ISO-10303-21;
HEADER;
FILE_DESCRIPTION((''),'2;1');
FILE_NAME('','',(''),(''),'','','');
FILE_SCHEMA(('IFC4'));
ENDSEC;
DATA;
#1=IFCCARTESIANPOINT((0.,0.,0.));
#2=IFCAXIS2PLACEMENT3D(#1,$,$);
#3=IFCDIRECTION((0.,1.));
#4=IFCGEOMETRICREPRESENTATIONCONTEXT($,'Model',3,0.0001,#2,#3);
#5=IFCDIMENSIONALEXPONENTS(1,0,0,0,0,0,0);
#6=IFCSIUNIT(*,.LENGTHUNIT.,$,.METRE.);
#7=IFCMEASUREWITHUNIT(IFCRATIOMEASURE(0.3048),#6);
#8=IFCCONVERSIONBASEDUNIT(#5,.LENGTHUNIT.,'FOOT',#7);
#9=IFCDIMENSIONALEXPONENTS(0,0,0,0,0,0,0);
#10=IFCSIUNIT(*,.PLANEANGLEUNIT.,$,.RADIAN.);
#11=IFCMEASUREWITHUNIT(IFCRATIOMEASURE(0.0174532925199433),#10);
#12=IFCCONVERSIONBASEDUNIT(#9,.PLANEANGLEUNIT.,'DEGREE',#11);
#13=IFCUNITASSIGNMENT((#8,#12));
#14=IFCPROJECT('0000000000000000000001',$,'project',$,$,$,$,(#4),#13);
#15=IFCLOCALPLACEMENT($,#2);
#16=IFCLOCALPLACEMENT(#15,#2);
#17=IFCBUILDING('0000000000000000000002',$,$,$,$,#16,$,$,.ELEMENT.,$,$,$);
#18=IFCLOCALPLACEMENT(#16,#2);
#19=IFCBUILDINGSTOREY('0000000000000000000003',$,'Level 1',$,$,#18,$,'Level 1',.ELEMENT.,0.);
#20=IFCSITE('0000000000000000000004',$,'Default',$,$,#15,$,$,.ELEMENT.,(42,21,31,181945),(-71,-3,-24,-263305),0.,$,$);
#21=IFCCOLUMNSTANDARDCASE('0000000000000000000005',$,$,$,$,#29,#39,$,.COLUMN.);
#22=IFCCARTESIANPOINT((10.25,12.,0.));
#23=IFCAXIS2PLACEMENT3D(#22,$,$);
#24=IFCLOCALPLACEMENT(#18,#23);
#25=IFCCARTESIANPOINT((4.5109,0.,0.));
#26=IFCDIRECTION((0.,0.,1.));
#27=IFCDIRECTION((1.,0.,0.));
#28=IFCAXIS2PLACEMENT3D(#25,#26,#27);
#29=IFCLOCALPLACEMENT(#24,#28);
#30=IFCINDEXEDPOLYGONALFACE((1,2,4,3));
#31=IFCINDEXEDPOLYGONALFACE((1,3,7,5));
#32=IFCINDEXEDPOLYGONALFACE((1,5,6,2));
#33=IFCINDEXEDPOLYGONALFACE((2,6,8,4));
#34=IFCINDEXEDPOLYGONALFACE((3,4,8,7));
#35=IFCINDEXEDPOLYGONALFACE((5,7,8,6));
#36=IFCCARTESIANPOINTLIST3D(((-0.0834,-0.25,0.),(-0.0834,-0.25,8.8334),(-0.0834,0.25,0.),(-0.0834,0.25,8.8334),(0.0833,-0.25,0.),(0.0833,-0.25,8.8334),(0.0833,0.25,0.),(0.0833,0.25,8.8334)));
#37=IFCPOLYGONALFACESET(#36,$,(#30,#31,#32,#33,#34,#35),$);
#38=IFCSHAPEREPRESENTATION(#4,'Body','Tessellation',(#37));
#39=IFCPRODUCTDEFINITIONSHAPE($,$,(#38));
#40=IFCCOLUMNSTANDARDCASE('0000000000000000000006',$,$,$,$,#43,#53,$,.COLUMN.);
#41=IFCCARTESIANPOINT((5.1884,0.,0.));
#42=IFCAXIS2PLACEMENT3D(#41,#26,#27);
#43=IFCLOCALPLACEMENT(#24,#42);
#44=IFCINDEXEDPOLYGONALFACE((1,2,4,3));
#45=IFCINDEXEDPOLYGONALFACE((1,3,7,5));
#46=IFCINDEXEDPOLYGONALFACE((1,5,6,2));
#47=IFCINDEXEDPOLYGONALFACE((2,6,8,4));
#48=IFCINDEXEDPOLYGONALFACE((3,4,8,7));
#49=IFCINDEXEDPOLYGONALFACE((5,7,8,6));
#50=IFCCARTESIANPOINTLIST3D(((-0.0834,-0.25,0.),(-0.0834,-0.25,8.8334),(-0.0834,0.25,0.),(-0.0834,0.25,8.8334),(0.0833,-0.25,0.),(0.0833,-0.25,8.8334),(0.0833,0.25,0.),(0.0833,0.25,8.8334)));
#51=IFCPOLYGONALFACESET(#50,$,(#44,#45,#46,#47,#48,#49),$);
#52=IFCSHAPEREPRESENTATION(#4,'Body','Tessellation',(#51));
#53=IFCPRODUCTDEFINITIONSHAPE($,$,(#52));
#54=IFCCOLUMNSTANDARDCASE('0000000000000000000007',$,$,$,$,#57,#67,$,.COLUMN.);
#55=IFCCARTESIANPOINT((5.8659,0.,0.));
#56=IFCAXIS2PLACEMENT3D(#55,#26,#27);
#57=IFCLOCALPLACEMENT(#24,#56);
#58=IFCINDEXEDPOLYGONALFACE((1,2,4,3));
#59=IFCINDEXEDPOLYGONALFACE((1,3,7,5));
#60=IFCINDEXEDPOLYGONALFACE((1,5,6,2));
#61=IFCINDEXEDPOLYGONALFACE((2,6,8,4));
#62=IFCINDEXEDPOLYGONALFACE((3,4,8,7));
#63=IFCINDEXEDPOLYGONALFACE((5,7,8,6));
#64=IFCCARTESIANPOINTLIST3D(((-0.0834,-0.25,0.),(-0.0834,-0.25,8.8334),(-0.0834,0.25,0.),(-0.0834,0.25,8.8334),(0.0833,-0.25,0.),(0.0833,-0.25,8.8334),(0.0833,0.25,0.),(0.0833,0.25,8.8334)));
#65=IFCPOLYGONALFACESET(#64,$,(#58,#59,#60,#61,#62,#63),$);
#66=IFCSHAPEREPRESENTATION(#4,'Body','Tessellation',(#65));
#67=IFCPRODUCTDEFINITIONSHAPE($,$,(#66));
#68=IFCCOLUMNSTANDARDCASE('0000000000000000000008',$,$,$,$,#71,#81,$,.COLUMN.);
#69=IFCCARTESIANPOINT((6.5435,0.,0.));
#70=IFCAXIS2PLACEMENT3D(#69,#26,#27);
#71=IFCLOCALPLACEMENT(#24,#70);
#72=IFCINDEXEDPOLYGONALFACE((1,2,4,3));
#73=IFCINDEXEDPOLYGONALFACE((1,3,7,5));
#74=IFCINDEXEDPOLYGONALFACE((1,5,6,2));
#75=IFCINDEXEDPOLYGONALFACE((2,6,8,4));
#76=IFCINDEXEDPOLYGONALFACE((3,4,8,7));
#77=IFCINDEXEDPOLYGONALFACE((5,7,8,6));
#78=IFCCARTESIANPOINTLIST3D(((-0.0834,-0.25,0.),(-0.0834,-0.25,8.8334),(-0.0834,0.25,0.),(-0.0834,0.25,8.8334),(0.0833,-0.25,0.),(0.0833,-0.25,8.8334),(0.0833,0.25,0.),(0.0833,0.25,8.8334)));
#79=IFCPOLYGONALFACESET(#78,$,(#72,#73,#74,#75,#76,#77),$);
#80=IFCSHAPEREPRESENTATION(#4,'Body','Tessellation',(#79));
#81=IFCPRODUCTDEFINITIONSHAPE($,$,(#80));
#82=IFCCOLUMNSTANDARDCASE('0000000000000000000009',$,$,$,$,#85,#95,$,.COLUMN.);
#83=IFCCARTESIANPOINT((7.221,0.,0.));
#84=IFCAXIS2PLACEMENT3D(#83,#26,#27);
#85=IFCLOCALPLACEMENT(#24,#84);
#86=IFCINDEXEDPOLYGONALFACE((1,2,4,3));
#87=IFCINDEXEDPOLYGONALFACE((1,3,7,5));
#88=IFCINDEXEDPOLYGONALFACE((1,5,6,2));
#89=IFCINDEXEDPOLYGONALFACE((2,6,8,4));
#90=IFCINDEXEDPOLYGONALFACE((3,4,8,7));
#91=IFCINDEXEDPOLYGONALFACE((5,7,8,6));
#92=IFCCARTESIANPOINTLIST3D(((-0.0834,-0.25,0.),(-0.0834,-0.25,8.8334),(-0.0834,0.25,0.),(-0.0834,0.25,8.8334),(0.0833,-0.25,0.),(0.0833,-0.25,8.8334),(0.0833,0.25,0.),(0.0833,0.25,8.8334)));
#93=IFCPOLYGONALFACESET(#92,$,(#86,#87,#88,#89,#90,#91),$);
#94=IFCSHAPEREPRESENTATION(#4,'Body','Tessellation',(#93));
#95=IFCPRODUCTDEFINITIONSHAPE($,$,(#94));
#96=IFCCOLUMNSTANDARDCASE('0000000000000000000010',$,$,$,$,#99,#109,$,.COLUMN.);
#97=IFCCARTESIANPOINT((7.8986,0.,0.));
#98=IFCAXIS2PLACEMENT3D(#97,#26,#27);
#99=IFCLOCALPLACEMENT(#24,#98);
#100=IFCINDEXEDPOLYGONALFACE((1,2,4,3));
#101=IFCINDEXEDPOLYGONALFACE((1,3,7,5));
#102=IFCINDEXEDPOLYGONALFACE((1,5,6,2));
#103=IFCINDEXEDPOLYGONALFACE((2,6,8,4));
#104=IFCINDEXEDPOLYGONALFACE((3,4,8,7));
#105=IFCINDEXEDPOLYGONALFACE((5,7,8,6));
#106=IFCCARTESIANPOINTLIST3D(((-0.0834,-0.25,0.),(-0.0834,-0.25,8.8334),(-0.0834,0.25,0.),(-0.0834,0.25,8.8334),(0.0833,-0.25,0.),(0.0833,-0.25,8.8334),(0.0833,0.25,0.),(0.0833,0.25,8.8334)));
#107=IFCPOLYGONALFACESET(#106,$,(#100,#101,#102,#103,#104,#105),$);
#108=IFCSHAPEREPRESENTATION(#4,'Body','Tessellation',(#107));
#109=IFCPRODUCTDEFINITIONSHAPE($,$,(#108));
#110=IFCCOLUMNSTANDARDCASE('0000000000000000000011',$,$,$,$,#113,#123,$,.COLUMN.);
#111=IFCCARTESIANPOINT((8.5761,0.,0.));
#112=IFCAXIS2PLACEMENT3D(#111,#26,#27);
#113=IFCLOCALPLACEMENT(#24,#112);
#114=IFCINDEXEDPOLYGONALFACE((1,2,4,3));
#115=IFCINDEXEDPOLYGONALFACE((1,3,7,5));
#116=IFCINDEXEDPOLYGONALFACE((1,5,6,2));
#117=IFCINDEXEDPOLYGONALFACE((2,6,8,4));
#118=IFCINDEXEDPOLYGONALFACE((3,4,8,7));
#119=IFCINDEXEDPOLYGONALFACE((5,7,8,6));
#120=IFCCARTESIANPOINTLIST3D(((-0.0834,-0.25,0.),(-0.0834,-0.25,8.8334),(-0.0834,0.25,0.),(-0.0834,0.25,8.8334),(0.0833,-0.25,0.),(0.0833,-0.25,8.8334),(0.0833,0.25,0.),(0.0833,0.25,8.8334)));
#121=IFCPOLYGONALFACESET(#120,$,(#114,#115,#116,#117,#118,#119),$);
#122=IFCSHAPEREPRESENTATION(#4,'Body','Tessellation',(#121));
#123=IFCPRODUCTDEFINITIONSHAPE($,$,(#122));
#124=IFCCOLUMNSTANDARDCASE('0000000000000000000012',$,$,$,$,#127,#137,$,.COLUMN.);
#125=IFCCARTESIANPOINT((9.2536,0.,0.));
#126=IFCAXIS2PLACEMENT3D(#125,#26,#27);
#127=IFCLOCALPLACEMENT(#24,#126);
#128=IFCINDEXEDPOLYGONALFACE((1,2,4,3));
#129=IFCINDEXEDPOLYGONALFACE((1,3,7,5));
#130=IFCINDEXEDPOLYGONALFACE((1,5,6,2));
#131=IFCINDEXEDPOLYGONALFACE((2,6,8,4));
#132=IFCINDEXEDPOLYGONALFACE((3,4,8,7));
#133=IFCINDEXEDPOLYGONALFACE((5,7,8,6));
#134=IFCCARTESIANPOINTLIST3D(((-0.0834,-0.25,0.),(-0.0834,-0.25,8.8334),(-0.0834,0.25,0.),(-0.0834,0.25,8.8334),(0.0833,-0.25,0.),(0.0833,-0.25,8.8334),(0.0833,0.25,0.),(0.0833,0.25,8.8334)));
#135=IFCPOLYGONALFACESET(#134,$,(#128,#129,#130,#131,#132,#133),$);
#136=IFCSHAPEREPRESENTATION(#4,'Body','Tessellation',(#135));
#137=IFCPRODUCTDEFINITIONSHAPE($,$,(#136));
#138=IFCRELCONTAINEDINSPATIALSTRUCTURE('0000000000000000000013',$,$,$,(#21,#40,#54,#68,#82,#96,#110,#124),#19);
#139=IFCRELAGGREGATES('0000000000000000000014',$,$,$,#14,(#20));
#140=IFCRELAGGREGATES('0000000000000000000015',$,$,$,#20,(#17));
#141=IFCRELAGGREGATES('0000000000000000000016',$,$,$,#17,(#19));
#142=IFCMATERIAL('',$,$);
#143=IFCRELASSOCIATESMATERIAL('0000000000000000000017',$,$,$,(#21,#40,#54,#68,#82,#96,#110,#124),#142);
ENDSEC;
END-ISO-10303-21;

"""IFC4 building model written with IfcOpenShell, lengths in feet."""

from ifc_helpers import new_model, entity, si_unit, converted_unit, direction, frame, origin, place, context, project, spatial, rectangle, extrude, material, element, save


model = new_model("IFC4")

# Units and contexts
model_context = context("Model", 3, precision=0.0001, world=origin(), true_north=direction((0.0, 1.0)))
ifc_project = project(units=[converted_unit("LENGTHUNIT", "FOOT", entity("IfcRatioMeasure", 0.3048), si_unit("LENGTHUNIT", "METRE"), dimensions=[1, 0, 0, 0, 0, 0, 0]), converted_unit("PLANEANGLEUNIT", "DEGREE", entity("IfcRatioMeasure", 0.0174532925199433), si_unit("PLANEANGLEUNIT", "RADIAN"), dimensions=[0, 0, 0, 0, 0, 0, 0])], contexts=[model_context])

# Site, building, storey
site_placement = place(None, origin())
site = spatial("IfcSite", under=ifc_project, at=site_placement, Name="Default", CompositionType="ELEMENT", RefLatitude=(42, 21, 31, 181945), RefLongitude=(-71, -3, -24, -263305), RefElevation=0.0)
building_placement = place(site_placement, origin())
building = spatial("IfcBuilding", under=site, at=building_placement, CompositionType="ELEMENT")
storey_placement = place(building_placement, origin())
storey = spatial("IfcBuildingStorey", under=building, at=storey_placement, Name="Level 1", LongName="Level 1", CompositionType="ELEMENT", Elevation=0.0)

# Columns
ifc_material_1 = material(Name="")
placement_1 = place(storey_placement, frame((10.25, 12.0, 0.0)))
for number, where, z_axis, x_axis in (
    (1, (4.5109, 0.0, 0.0), (0.0, 0.0, 1.0), (1.0, 0.0, 0.0)),
    (2, (5.1884, 0.0, 0.0), (0.0, 0.0, 1.0), (1.0, 0.0, 0.0)),
    (3, (5.8659, 0.0, 0.0), (0.0, 0.0, 1.0), (1.0, 0.0, 0.0)),
    (4, (6.5435, 0.0, 0.0), (0.0, 0.0, 1.0), (1.0, 0.0, 0.0)),
    (5, (7.221, 0.0, 0.0), (0.0, 0.0, 1.0), (1.0, 0.0, 0.0)),
    (6, (7.8986, 0.0, 0.0), (0.0, 0.0, 1.0), (1.0, 0.0, 0.0)),
    (7, (8.5761, 0.0, 0.0), (0.0, 0.0, 1.0), (1.0, 0.0, 0.0)),
    (8, (9.2536, 0.0, 0.0), (0.0, 0.0, 1.0), (1.0, 0.0, 0.0)),
):
    element("IfcColumnStandardCase", number, at=place(placement_1, frame(where, z_axis=z_axis, x_axis=x_axis)), inside=storey, material=ifc_material_1, PredefinedType="COLUMN", context=model_context, shape_type="SweptSolid", body=[
        extrude(rectangle(XDim=0.1667, YDim=0.5), origin(), (0.0, 0.0, 1.0), 8.8334),
    ])

save(model, "model.ifc")
